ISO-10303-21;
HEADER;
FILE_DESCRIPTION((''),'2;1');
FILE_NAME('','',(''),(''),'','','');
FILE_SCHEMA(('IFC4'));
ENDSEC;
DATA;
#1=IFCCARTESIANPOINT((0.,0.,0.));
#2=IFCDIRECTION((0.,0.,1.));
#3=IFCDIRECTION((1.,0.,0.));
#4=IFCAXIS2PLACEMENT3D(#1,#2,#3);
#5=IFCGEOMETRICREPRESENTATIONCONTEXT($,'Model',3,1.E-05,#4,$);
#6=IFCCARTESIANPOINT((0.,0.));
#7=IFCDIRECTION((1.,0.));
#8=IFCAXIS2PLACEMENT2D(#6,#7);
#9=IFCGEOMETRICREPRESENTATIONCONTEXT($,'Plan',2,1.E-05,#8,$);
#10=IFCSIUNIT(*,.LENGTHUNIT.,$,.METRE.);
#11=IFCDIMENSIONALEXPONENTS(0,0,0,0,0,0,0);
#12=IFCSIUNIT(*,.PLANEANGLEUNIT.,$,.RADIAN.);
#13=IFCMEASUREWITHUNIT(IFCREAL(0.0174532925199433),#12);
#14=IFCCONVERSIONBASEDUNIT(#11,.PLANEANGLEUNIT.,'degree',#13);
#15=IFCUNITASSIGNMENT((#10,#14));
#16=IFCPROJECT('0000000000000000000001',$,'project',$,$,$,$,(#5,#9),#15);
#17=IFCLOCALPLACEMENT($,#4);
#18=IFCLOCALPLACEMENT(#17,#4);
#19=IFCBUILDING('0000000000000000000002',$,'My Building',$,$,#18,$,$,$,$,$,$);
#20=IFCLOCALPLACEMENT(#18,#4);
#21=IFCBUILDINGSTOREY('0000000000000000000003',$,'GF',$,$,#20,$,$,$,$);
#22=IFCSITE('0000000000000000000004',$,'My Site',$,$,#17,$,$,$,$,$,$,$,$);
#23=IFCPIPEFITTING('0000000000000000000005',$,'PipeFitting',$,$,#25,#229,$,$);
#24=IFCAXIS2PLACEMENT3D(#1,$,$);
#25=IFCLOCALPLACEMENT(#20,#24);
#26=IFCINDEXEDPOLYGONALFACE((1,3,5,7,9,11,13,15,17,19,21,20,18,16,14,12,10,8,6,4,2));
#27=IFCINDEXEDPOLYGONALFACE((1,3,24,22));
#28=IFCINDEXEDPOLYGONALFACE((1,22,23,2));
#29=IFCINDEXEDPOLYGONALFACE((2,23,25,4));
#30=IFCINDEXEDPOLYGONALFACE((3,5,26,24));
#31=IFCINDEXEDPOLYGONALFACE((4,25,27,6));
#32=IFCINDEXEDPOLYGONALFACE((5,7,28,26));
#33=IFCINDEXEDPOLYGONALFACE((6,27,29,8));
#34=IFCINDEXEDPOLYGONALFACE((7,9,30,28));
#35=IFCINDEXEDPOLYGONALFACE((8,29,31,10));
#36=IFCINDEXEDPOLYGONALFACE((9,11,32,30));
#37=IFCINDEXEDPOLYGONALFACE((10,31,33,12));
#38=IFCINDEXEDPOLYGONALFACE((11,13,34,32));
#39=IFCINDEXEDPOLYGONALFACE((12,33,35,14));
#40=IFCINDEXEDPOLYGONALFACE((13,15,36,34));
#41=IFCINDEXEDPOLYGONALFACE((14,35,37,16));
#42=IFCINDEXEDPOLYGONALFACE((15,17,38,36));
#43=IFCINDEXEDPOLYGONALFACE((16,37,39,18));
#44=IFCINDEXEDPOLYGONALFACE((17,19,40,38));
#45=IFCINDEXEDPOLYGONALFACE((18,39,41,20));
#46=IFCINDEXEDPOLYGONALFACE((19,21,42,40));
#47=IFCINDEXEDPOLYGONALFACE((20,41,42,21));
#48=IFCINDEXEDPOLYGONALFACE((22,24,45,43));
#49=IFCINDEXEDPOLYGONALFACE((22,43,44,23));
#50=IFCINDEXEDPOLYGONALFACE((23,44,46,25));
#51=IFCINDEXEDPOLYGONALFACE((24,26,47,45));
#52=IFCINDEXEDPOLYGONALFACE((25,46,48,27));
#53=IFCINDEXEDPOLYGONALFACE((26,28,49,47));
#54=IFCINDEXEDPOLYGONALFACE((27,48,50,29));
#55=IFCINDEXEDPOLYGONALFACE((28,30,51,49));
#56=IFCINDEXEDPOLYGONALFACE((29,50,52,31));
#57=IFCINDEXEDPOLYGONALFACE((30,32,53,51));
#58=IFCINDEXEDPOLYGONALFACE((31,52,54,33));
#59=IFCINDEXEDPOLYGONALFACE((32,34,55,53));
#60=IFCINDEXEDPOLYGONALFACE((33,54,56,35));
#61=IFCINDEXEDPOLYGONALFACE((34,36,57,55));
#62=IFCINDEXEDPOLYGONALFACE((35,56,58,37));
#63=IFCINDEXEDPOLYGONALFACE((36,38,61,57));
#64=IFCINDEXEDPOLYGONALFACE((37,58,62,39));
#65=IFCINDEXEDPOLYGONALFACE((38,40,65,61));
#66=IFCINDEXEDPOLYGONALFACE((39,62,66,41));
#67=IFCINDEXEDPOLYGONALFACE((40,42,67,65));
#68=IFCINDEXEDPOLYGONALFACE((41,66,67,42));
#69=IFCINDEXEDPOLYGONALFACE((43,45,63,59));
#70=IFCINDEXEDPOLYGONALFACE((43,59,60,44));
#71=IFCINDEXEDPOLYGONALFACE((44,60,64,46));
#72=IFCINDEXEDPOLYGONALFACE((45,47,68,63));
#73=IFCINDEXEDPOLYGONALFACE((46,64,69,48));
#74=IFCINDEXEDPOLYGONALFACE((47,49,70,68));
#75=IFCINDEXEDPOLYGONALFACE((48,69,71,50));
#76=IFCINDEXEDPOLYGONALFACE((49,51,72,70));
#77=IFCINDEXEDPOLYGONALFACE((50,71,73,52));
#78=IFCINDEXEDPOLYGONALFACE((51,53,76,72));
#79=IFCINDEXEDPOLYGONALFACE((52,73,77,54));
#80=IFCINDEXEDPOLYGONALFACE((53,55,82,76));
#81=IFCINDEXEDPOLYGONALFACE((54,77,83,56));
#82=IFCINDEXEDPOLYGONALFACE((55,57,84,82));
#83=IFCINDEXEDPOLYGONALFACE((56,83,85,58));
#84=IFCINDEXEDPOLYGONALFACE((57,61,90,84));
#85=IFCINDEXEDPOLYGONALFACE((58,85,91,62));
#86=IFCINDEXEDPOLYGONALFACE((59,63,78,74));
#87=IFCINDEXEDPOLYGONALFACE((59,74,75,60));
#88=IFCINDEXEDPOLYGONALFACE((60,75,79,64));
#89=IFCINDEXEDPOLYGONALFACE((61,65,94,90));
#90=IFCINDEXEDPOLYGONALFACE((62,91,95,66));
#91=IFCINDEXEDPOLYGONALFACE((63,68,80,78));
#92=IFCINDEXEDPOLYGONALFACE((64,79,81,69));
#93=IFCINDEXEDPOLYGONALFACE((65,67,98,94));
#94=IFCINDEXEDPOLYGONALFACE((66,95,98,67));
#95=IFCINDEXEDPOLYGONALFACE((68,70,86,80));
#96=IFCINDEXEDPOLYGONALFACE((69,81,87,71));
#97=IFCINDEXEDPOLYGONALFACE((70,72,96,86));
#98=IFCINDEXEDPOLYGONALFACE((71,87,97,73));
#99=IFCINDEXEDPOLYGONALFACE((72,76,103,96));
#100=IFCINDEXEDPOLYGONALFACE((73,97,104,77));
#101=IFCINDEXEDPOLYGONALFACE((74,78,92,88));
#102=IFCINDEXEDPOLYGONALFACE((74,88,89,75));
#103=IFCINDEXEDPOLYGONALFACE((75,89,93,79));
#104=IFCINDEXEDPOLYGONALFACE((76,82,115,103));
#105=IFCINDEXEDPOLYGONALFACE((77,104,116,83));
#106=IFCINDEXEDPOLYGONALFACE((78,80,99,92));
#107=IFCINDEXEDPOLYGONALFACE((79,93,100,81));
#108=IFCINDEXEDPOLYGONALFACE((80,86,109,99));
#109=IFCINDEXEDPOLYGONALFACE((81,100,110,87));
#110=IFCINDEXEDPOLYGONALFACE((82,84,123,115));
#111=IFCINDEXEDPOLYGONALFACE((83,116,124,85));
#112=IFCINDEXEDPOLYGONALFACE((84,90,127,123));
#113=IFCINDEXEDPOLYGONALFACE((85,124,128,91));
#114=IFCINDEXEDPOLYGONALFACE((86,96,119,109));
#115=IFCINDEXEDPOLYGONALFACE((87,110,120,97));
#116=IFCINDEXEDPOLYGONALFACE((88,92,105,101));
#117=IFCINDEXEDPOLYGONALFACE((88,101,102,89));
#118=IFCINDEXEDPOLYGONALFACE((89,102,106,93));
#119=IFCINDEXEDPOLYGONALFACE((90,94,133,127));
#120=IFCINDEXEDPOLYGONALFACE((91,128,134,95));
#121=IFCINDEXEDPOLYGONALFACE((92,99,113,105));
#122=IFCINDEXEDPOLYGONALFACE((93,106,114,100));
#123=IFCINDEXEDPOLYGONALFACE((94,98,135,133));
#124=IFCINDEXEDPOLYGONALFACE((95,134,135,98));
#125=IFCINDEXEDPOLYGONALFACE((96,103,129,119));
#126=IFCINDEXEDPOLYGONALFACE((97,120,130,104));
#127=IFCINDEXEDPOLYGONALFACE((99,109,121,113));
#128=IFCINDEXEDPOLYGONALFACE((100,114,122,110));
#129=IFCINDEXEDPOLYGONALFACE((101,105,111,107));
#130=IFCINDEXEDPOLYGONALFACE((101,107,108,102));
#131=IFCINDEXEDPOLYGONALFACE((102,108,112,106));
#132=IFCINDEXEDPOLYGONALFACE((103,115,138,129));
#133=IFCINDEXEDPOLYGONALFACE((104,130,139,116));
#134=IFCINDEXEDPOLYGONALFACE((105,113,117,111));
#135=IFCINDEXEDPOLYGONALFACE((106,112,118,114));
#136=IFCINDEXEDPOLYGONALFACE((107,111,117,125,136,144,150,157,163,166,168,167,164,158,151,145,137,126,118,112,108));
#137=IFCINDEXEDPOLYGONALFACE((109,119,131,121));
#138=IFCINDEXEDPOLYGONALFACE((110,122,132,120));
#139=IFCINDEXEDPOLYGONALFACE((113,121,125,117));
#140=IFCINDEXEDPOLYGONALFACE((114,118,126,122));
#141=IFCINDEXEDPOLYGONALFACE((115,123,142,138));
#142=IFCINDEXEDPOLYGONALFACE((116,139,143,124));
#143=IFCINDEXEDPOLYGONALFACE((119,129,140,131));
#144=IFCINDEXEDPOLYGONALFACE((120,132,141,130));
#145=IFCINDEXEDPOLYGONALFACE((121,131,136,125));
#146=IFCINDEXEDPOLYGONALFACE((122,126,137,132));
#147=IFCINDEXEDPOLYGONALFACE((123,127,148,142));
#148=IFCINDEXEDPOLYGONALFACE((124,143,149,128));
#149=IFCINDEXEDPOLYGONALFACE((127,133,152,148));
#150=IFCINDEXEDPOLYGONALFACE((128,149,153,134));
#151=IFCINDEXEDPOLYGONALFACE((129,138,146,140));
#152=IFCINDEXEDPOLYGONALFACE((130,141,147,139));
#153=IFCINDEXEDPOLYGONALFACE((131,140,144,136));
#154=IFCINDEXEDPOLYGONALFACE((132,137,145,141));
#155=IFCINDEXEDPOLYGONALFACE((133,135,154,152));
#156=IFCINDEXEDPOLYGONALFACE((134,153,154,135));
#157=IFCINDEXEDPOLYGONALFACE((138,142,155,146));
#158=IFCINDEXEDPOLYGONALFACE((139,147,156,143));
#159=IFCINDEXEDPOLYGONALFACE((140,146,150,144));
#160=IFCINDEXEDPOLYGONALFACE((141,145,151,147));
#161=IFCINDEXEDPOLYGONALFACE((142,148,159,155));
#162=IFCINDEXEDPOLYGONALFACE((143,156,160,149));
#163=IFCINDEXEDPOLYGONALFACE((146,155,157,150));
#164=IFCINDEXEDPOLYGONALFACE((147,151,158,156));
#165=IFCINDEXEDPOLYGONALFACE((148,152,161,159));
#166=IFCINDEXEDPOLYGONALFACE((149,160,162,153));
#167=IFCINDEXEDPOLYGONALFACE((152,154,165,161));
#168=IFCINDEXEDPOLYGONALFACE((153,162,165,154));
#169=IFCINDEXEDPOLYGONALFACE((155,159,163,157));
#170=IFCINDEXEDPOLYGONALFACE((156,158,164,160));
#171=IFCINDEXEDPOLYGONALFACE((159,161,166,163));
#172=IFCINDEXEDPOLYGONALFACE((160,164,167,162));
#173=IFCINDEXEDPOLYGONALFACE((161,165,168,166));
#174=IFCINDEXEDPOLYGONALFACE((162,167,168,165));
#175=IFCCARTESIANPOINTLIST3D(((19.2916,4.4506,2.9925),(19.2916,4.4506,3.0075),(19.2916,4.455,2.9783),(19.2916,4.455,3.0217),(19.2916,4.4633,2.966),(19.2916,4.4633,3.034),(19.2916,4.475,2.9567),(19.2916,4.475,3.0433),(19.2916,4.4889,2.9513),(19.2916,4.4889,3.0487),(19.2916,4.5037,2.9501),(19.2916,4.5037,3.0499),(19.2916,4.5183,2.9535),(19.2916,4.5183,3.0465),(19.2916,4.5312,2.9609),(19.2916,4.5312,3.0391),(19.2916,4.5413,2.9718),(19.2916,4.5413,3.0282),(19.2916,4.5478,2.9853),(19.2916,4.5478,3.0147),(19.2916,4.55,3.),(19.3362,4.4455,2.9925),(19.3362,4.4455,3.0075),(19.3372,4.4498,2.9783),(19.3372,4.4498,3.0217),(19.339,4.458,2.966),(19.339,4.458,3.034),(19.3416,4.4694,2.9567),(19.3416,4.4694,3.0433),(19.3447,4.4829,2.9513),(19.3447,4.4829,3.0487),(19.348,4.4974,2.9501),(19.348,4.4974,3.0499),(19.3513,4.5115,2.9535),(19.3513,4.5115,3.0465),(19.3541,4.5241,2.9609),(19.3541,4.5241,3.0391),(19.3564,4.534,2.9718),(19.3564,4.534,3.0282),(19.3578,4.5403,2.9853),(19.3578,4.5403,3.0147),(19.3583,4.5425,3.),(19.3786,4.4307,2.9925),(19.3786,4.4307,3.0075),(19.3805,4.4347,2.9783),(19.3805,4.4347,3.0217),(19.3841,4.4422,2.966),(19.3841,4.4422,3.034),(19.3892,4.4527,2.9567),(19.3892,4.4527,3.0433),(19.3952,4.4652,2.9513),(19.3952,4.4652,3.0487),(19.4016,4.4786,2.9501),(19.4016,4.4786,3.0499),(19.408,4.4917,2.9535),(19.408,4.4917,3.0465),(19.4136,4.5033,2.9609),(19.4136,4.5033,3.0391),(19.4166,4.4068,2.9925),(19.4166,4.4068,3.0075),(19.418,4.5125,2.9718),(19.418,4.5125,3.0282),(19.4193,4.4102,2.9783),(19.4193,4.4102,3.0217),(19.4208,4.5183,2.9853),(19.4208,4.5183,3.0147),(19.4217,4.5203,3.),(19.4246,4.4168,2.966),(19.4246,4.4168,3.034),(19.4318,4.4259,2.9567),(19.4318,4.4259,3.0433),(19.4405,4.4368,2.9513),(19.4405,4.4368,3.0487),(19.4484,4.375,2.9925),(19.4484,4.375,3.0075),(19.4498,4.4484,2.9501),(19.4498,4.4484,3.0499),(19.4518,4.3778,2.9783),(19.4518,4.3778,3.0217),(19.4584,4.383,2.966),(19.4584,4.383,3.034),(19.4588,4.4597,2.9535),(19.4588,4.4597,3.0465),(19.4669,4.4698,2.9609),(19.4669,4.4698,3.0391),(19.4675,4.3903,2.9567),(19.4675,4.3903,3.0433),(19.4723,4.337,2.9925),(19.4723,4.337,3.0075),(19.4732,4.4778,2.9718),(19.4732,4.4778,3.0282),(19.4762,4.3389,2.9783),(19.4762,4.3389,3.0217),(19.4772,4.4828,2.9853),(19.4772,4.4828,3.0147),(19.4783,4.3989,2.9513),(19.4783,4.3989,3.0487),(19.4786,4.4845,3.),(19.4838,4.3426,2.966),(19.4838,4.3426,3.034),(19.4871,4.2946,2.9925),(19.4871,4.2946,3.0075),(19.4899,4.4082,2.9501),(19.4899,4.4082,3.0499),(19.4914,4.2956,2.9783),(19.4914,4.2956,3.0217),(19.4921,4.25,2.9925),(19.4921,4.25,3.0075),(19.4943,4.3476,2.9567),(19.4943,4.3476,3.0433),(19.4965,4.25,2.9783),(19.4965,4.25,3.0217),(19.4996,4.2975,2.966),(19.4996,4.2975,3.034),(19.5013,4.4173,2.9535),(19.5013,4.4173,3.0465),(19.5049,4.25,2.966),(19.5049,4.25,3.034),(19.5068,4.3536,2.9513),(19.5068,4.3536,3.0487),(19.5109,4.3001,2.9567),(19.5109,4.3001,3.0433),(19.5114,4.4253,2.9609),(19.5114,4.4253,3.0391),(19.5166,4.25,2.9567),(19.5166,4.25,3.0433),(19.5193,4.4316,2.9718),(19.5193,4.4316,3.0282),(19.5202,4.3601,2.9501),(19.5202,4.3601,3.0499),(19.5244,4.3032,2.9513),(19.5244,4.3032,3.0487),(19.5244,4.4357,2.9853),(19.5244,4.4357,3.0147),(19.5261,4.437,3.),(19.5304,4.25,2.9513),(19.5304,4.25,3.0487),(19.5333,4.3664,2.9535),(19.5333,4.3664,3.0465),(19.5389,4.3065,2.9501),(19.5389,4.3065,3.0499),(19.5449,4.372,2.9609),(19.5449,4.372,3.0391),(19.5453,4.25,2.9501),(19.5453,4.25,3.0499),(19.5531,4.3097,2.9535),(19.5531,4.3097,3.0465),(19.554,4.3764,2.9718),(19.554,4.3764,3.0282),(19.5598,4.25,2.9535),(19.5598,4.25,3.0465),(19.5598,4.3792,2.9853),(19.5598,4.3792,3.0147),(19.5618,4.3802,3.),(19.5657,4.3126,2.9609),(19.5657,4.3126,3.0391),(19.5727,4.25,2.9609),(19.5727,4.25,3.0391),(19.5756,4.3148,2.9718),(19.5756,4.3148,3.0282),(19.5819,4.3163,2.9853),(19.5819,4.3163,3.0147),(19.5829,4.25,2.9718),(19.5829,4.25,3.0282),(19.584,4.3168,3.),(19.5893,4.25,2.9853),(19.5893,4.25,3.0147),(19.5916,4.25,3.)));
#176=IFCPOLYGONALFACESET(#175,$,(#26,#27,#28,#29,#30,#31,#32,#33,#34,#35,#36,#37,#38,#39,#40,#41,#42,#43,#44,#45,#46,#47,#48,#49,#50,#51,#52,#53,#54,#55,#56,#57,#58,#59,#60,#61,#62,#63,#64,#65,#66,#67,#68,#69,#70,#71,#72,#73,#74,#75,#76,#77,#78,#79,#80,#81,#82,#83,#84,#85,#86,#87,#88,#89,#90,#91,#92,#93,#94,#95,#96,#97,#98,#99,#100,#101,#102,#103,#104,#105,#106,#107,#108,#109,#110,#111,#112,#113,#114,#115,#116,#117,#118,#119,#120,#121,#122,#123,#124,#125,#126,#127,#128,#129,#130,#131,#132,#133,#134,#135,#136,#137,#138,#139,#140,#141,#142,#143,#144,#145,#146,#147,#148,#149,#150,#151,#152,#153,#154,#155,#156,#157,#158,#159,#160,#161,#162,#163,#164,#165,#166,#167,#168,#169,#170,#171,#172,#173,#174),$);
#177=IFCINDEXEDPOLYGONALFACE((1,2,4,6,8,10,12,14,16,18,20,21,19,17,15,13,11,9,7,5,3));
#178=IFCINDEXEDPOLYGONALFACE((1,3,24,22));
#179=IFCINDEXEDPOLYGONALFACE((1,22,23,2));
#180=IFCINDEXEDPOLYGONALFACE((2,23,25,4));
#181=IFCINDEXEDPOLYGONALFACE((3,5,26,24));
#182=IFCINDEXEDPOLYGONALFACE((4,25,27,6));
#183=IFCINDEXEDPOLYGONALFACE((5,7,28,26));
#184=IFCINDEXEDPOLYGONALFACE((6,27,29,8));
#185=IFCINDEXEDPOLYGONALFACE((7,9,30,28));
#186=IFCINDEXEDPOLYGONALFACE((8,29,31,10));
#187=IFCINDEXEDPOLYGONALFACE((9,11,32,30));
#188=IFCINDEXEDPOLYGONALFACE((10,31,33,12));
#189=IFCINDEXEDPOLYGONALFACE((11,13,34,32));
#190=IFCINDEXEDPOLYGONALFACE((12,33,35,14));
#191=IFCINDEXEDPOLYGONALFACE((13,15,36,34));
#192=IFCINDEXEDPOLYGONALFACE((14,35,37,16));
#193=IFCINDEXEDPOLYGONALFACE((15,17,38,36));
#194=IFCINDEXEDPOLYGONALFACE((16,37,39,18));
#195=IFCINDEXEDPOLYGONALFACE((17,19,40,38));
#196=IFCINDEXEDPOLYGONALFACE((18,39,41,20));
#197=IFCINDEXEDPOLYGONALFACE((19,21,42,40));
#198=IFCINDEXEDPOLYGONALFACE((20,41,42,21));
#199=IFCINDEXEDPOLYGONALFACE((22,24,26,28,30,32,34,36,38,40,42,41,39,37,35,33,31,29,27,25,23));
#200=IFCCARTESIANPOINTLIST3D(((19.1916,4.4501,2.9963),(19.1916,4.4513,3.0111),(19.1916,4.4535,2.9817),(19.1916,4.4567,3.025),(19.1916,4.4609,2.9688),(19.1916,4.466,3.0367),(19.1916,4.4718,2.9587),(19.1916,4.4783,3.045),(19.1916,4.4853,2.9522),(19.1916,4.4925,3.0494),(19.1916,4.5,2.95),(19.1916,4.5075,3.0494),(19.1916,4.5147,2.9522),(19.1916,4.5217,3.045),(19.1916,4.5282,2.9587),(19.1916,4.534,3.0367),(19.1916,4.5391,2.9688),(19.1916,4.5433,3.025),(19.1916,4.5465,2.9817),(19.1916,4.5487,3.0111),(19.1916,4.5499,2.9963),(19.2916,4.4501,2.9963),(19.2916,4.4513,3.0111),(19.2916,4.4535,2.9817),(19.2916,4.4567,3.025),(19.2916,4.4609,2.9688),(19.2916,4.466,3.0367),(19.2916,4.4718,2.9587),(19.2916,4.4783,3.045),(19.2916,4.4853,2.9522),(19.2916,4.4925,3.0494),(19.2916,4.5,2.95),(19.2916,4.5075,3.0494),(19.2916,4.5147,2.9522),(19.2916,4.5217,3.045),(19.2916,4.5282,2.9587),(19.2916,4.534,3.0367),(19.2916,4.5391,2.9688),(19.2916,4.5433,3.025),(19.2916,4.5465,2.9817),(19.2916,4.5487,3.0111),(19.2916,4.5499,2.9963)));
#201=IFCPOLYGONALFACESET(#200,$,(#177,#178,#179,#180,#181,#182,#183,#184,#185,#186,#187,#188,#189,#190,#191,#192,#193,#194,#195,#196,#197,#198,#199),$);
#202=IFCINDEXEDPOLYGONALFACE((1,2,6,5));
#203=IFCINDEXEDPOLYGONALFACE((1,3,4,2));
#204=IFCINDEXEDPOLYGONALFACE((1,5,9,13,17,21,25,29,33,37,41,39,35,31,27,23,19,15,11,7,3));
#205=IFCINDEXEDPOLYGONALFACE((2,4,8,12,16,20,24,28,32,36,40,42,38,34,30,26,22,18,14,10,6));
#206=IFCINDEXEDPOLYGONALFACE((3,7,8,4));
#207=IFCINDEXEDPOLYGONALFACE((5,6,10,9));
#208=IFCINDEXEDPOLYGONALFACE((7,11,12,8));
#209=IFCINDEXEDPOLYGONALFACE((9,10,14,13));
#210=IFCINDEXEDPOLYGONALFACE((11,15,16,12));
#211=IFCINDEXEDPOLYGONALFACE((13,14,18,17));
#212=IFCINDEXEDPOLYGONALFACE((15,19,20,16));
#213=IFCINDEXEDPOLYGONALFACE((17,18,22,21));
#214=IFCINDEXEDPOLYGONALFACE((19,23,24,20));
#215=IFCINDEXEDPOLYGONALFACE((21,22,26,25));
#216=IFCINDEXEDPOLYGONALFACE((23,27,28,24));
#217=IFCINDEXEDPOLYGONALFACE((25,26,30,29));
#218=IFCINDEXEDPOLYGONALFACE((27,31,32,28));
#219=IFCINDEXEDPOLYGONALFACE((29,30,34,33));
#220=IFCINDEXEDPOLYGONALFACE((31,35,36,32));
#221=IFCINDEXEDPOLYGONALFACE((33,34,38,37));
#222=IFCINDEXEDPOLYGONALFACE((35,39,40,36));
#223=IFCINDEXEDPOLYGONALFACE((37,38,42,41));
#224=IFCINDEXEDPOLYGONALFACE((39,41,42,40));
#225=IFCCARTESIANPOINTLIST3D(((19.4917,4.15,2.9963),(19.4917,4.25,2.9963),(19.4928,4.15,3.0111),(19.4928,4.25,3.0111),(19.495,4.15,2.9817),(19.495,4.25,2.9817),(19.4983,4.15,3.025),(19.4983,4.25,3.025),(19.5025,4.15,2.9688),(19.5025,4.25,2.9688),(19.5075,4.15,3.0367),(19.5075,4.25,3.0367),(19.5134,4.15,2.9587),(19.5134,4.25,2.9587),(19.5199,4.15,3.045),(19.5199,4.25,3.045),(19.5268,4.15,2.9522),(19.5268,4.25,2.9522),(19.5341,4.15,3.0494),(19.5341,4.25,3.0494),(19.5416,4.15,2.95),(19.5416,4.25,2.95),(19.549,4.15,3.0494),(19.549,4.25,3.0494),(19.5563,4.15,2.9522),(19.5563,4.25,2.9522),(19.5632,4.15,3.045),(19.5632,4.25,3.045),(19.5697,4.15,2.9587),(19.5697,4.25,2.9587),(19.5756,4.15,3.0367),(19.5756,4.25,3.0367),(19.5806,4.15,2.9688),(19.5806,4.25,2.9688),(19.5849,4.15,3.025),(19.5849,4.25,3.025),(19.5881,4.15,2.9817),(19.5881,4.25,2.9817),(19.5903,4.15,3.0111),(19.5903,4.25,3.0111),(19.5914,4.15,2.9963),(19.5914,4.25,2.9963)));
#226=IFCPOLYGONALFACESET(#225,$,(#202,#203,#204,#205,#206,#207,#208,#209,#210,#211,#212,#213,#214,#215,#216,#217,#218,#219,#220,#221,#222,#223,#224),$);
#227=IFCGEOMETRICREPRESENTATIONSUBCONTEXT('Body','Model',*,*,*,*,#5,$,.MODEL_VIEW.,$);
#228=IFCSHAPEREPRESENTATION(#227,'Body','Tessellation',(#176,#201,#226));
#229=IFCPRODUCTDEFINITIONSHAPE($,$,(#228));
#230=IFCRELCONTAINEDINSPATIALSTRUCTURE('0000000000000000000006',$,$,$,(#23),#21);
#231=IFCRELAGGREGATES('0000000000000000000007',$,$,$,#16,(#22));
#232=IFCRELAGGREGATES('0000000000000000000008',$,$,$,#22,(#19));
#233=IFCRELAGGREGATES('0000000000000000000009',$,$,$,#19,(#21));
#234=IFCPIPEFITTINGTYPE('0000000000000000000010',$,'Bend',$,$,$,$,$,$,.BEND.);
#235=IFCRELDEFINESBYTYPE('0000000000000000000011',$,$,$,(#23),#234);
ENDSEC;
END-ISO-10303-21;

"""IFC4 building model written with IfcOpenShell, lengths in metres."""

from ifc_helpers import new_model, entity, si_unit, converted_unit, frame, origin_with_axes, origin_2d_with_axis, place, context, subcontext, project, spatial, circle, extrude, source, transform, mapped, type_object, type_shapes, element, save


model = new_model("IFC4")

# Units and contexts
model_context = context("Model", 3, precision=1e-05, world=origin_with_axes())
plan_context = context("Plan", 2, precision=1e-05, world=origin_2d_with_axis())
body_context_1 = subcontext(model_context, "Body", "Model", "MODEL_VIEW")
ifc_project = project(units=[si_unit("LENGTHUNIT", "METRE"), converted_unit("PLANEANGLEUNIT", "degree", entity("IfcReal", 0.0174532925199433), si_unit("PLANEANGLEUNIT", "RADIAN"), dimensions=[0, 0, 0, 0, 0, 0, 0])], contexts=[model_context, plan_context])

# Site, building, storey
site_placement = place(None, origin_with_axes())
site = spatial("IfcSite", under=ifc_project, at=site_placement, Name="My Site")
building_placement = place(site_placement, origin_with_axes())
building = spatial("IfcBuilding", under=site, at=building_placement, Name="My Building")
storey_placement = place(building_placement, origin_with_axes())
storey = spatial("IfcBuildingStorey", under=building, at=storey_placement, Name="GF")

# Pipe fitting
pipe_fitting_type = type_object("IfcPipeFittingType", Name="Bend", PredefinedType="BEND")
shared_shape_1 = source(origin_with_axes(), body_context_1, "Body", "SolidModel", [
    entity("IfcSweptDiskSolid", entity("IfcIndexedPolyCurve", entity("IfcCartesianPointList3D", [[0.0, 0.0, -0.1], [0.0, 0.0732, -0.2768], [0.0, 0.25, -0.35]]), [entity("IfcArcIndex", [1, 2, 3])]), 0.05),
    extrude(circle(Radius=0.05), origin_with_axes(), (0.0, 0.0, -1.0), 0.1),
    extrude(circle(Radius=0.05), frame((0.0, 0.25, -0.35), z_axis=(0.0, 1.0, 0.0), x_axis=(1.0, 0.0, 0.0)), (0.0, 0.0, 1.0), 0.1),
])
type_shapes(pipe_fitting_type, [shared_shape_1])
for number, where, z_axis, x_axis, name in (
    (1, (19.1916, 4.5, 3.0), (-1.0, 0.0, 0.0), (0.0, 0.0, -1.0), "PipeFitting"),
):
    element("IfcPipeFitting", number, at=place(storey_placement, frame(where, z_axis=z_axis, x_axis=x_axis)), inside=storey, type_object=pipe_fitting_type, Name=name, context=body_context_1, shape_type="MappedRepresentation", body=[
        mapped(shared_shape_1, transform((0.0, 0.0, 0.0), x_axis=(1.0, 0.0, 0.0), y_axis=(0.0, 1.0, 0.0), z_axis=(0.0, 0.0, 1.0), scale=1.0)),
    ])

save(model, "model.ifc")
